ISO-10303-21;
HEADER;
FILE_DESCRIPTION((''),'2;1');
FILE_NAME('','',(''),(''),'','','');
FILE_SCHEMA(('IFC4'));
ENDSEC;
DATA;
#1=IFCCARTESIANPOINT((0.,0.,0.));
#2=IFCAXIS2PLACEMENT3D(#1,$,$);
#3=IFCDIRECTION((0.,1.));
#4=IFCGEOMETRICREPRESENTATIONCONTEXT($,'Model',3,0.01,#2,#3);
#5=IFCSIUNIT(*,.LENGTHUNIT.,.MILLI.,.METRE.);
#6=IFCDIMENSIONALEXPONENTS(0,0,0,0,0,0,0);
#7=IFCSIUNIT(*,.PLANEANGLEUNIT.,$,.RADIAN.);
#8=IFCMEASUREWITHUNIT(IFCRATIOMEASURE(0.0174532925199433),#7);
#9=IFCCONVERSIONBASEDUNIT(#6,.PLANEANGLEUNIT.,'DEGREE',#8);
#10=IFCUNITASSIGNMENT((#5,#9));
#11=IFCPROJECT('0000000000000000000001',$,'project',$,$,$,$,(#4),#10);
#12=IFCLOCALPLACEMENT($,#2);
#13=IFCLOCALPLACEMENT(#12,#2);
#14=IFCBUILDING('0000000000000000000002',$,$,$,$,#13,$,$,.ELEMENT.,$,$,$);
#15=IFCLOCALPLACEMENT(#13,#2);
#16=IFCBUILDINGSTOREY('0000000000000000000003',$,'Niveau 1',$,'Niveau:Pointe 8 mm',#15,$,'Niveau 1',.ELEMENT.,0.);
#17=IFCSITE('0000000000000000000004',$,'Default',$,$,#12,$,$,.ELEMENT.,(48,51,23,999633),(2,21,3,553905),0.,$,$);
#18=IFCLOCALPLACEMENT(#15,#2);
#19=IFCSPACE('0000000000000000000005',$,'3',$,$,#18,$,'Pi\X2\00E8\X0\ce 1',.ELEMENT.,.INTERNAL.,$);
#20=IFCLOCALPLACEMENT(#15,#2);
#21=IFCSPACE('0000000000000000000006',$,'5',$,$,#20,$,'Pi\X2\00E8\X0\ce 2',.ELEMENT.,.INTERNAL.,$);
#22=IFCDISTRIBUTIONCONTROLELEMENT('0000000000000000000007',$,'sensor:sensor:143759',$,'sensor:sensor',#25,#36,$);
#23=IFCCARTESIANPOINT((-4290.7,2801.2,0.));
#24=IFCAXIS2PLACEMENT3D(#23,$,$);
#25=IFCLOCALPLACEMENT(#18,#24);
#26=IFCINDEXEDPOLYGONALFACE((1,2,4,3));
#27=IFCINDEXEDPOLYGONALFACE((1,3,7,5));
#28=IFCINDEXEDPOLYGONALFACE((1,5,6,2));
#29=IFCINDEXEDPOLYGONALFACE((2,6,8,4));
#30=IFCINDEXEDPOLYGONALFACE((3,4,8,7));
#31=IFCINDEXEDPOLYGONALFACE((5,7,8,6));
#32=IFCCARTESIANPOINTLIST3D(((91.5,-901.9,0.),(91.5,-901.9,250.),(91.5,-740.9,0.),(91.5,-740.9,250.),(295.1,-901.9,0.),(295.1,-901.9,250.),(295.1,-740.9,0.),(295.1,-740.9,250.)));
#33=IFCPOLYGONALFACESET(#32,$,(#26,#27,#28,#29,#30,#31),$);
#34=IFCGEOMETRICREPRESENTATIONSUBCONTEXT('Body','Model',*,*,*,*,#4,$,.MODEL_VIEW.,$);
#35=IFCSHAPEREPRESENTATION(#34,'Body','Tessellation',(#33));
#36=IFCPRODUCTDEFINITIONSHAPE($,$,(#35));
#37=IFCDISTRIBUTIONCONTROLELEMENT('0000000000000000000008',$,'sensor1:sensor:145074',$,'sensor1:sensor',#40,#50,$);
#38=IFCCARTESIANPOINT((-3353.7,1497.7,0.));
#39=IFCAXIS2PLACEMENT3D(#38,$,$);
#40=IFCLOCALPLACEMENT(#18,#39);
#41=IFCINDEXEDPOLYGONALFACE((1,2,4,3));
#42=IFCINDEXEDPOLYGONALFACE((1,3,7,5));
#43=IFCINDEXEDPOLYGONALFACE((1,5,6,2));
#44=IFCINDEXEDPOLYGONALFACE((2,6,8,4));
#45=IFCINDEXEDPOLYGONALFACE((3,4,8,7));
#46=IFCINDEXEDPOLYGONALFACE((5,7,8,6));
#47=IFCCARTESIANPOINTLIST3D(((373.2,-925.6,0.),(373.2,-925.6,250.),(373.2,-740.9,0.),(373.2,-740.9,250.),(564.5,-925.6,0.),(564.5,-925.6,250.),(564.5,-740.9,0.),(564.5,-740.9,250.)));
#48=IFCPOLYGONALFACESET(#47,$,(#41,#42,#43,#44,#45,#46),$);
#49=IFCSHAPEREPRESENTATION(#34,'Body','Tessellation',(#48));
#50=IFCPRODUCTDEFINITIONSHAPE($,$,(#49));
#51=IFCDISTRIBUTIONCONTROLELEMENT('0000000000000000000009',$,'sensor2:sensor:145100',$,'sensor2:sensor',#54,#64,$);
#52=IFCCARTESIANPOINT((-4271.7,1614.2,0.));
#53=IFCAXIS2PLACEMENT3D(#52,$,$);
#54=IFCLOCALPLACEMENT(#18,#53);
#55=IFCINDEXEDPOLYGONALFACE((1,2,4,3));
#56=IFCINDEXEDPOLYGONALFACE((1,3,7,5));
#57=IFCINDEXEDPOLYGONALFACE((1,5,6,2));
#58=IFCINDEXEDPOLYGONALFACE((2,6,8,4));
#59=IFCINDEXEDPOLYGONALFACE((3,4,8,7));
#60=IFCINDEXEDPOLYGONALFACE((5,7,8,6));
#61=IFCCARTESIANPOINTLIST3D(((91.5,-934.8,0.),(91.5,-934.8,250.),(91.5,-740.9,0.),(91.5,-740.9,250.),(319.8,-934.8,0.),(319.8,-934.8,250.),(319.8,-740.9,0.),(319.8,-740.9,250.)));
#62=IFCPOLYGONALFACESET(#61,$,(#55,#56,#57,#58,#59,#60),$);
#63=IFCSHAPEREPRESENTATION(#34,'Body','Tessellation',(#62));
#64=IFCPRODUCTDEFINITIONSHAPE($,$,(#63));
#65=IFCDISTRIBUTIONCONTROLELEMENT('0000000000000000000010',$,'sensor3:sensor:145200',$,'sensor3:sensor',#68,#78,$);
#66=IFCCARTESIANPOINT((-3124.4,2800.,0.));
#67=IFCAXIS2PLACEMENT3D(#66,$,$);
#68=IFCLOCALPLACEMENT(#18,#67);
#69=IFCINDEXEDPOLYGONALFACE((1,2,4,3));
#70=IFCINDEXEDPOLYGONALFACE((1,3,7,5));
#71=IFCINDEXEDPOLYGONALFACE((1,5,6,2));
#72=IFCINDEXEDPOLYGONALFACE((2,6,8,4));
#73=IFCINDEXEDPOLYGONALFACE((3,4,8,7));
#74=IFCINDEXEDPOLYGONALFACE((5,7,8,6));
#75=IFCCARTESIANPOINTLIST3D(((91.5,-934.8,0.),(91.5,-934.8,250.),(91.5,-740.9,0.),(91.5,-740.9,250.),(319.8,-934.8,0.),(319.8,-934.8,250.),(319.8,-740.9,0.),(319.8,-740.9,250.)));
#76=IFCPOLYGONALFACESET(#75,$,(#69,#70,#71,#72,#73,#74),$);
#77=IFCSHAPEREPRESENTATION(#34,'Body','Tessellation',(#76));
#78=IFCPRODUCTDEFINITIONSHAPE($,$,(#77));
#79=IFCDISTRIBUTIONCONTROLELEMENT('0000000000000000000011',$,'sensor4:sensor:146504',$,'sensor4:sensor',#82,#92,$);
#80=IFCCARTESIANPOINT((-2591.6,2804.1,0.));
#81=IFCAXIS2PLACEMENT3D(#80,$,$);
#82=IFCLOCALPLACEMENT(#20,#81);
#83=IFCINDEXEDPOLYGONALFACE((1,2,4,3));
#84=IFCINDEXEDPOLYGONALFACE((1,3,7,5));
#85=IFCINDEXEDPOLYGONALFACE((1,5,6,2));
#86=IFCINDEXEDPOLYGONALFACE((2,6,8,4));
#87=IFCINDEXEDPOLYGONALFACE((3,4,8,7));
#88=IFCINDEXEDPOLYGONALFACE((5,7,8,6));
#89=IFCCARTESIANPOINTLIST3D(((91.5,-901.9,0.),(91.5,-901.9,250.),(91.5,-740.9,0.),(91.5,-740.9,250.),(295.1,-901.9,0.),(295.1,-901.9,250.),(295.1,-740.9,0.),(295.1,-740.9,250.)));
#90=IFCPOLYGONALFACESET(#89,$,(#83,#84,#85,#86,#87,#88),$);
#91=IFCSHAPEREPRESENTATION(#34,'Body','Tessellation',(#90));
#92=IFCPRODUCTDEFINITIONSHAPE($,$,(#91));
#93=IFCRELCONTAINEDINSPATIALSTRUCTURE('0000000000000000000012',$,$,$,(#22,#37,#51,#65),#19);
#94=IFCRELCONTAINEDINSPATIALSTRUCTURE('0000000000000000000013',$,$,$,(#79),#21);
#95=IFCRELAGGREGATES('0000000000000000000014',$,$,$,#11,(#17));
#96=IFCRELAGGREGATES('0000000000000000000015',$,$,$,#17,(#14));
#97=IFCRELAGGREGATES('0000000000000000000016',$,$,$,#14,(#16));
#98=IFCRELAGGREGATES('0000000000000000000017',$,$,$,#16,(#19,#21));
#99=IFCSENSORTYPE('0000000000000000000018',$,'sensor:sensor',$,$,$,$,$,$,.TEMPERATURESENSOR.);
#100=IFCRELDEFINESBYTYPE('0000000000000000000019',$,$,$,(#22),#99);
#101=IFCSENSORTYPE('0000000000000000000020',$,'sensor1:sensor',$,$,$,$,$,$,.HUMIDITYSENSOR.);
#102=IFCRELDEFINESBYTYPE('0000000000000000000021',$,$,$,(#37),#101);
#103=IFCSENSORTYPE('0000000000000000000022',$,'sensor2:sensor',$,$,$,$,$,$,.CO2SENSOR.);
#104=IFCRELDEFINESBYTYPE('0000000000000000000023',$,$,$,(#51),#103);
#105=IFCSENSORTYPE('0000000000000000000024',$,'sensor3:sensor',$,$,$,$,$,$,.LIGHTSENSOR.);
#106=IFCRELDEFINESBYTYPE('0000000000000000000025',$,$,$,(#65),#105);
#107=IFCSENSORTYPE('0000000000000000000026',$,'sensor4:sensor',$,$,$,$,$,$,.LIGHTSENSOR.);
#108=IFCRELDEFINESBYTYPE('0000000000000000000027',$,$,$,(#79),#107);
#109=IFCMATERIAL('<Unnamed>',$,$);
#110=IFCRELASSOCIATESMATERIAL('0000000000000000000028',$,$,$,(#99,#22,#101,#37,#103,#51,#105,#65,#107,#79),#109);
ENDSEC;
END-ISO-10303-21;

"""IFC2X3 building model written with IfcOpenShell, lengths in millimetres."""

from ifc_helpers import new_model, entity, si_unit, converted_unit, direction, frame, origin, origin_2d_with_axis, place, context, subcontext, project, spatial, rectangle, extrude, source, transform, mapped, material, type_object, type_shapes, element, save


model = new_model("IFC2X3")

# Units and contexts
model_context = context("Model", 3, precision=0.01, world=origin(), true_north=direction((0.0, 1.0)))
body_context = subcontext(model_context, "Body", "Model", "MODEL_VIEW")
ifc_project = project(units=[si_unit("LENGTHUNIT", "METRE", prefix="MILLI"), converted_unit("PLANEANGLEUNIT", "DEGREE", entity("IfcRatioMeasure", 0.0174532925199433), si_unit("PLANEANGLEUNIT", "RADIAN"), dimensions=[0, 0, 0, 0, 0, 0, 0])], contexts=[model_context])

# Site, building, storey
site_placement = place(None, origin())
site = spatial("IfcSite", under=ifc_project, at=site_placement, Name="Default", CompositionType="ELEMENT", RefLatitude=(48, 51, 23, 999633), RefLongitude=(2, 21, 3, 553905), RefElevation=0.0)
building_placement = place(site_placement, origin())
building = spatial("IfcBuilding", under=site, at=building_placement, CompositionType="ELEMENT")
storey_placement = place(building_placement, origin())
storey = spatial("IfcBuildingStorey", under=building, at=storey_placement, Name="Niveau 1", ObjectType="Niveau:Pointe 8 mm", LongName="Niveau 1", CompositionType="ELEMENT", Elevation=0.0)

# Shared definitions
space_1_placement = place(storey_placement, origin())
space_1 = spatial("IfcSpace", under=storey, at=space_1_placement, Name="3", LongName="Pièce 1", CompositionType="ELEMENT", InteriorOrExteriorSpace="INTERNAL")

# Distribution control elements
ifc_material_1 = material(Name="<Unnamed>")
sensor_type_1 = type_object("IfcSensorType", Name="sensor:sensor", PredefinedType="TEMPERATURESENSOR", material=ifc_material_1)
shared_shape_1 = source(origin(), body_context, "Body", "SweptSolid", [
    extrude(rectangle(XDim=203.6, YDim=161.0, at=origin_2d_with_axis()), frame((193.3, -821.4, 0.0), z_axis=(0.0, 0.0, 1.0), x_axis=(-1.0, 0.0, 0.0)), (0.0, 0.0, 1.0), 250.0),
])
type_shapes(sensor_type_1, [shared_shape_1])
distribution_control_element_1_placement = place(space_1_placement, frame((-4290.7, 2801.2, 0.0)))
element("IfcDistributionControlElement", 1, at=distribution_control_element_1_placement, inside=space_1, type_object=sensor_type_1, material=ifc_material_1, Name="sensor:sensor:143759", ObjectType="sensor:sensor", context=body_context, shape_type="MappedRepresentation", body=[
    mapped(shared_shape_1, transform((0.0, 0.0, 0.0), scale=1.0)),
])
sensor_type_2 = type_object("IfcSensorType", Name="sensor1:sensor", PredefinedType="HUMIDITYSENSOR", material=ifc_material_1)
shared_shape_2 = source(origin(), body_context, "Body", "SweptSolid", [
    extrude(rectangle(XDim=191.3, YDim=184.7, at=origin_2d_with_axis()), frame((468.8, -833.2, 0.0), z_axis=(0.0, 0.0, 1.0), x_axis=(-1.0, 0.0, 0.0)), (0.0, 0.0, 1.0), 250.0),
])
type_shapes(sensor_type_2, [shared_shape_2])
distribution_control_element_2_placement = place(space_1_placement, frame((-3353.7, 1497.7, 0.0)))
element("IfcDistributionControlElement", 2, at=distribution_control_element_2_placement, inside=space_1, type_object=sensor_type_2, material=ifc_material_1, Name="sensor1:sensor:145074", ObjectType="sensor1:sensor", context=body_context, shape_type="MappedRepresentation", body=[
    mapped(shared_shape_2, transform((0.0, 0.0, 0.0), scale=1.0)),
])
sensor_type_3 = type_object("IfcSensorType", Name="sensor2:sensor", PredefinedType="CO2SENSOR", material=ifc_material_1)
shared_shape_3 = source(origin(), body_context, "Body", "SweptSolid", [
    extrude(rectangle(XDim=228.4, YDim=193.9, at=origin_2d_with_axis()), frame((205.7, -837.9, 0.0), z_axis=(0.0, 0.0, 1.0), x_axis=(-1.0, 0.0, 0.0)), (0.0, 0.0, 1.0), 250.0),
])
type_shapes(sensor_type_3, [shared_shape_3])
distribution_control_element_3_placement = place(space_1_placement, frame((-4271.7, 1614.2, 0.0)))
element("IfcDistributionControlElement", 3, at=distribution_control_element_3_placement, inside=space_1, type_object=sensor_type_3, material=ifc_material_1, Name="sensor2:sensor:145100", ObjectType="sensor2:sensor", context=body_context, shape_type="MappedRepresentation", body=[
    mapped(shared_shape_3, transform((0.0, 0.0, 0.0), scale=1.0)),
])
sensor_type_4 = type_object("IfcSensorType", Name="sensor3:sensor", PredefinedType="LIGHTSENSOR", material=ifc_material_1)
shared_shape_4 = source(origin(), body_context, "Body", "SweptSolid", [
    extrude(rectangle(XDim=228.4, YDim=193.9, at=origin_2d_with_axis()), frame((205.7, -837.9, 0.0), z_axis=(0.0, 0.0, 1.0), x_axis=(-1.0, 0.0, 0.0)), (0.0, 0.0, 1.0), 250.0),
])
type_shapes(sensor_type_4, [shared_shape_4])
distribution_control_element_4_placement = place(space_1_placement, frame((-3124.4, 2800.0, 0.0)))
element("IfcDistributionControlElement", 4, at=distribution_control_element_4_placement, inside=space_1, type_object=sensor_type_4, material=ifc_material_1, Name="sensor3:sensor:145200", ObjectType="sensor3:sensor", context=body_context, shape_type="MappedRepresentation", body=[
    mapped(shared_shape_4, transform((0.0, 0.0, 0.0), scale=1.0)),
])

# Shared definitions
space_2_placement = place(storey_placement, origin())
space_2 = spatial("IfcSpace", under=storey, at=space_2_placement, Name="5", LongName="Pièce 2", CompositionType="ELEMENT", InteriorOrExteriorSpace="INTERNAL")

# Distribution control element
sensor_type_5 = type_object("IfcSensorType", Name="sensor4:sensor", PredefinedType="LIGHTSENSOR", material=ifc_material_1)
shared_shape_5 = source(origin(), body_context, "Body", "SweptSolid", [
    extrude(rectangle(XDim=203.6, YDim=161.0, at=origin_2d_with_axis()), frame((193.3, -821.4, 0.0), z_axis=(0.0, 0.0, 1.0), x_axis=(-1.0, 0.0, 0.0)), (0.0, 0.0, 1.0), 250.0),
])
type_shapes(sensor_type_5, [shared_shape_5])
distribution_control_element_5_placement = place(space_2_placement, frame((-2591.6, 2804.1, 0.0)))
element("IfcDistributionControlElement", 5, at=distribution_control_element_5_placement, inside=space_2, type_object=sensor_type_5, material=ifc_material_1, Name="sensor4:sensor:146504", ObjectType="sensor4:sensor", context=body_context, shape_type="MappedRepresentation", body=[
    mapped(shared_shape_5, transform((0.0, 0.0, 0.0), scale=1.0)),
])

save(model, "model.ifc")
